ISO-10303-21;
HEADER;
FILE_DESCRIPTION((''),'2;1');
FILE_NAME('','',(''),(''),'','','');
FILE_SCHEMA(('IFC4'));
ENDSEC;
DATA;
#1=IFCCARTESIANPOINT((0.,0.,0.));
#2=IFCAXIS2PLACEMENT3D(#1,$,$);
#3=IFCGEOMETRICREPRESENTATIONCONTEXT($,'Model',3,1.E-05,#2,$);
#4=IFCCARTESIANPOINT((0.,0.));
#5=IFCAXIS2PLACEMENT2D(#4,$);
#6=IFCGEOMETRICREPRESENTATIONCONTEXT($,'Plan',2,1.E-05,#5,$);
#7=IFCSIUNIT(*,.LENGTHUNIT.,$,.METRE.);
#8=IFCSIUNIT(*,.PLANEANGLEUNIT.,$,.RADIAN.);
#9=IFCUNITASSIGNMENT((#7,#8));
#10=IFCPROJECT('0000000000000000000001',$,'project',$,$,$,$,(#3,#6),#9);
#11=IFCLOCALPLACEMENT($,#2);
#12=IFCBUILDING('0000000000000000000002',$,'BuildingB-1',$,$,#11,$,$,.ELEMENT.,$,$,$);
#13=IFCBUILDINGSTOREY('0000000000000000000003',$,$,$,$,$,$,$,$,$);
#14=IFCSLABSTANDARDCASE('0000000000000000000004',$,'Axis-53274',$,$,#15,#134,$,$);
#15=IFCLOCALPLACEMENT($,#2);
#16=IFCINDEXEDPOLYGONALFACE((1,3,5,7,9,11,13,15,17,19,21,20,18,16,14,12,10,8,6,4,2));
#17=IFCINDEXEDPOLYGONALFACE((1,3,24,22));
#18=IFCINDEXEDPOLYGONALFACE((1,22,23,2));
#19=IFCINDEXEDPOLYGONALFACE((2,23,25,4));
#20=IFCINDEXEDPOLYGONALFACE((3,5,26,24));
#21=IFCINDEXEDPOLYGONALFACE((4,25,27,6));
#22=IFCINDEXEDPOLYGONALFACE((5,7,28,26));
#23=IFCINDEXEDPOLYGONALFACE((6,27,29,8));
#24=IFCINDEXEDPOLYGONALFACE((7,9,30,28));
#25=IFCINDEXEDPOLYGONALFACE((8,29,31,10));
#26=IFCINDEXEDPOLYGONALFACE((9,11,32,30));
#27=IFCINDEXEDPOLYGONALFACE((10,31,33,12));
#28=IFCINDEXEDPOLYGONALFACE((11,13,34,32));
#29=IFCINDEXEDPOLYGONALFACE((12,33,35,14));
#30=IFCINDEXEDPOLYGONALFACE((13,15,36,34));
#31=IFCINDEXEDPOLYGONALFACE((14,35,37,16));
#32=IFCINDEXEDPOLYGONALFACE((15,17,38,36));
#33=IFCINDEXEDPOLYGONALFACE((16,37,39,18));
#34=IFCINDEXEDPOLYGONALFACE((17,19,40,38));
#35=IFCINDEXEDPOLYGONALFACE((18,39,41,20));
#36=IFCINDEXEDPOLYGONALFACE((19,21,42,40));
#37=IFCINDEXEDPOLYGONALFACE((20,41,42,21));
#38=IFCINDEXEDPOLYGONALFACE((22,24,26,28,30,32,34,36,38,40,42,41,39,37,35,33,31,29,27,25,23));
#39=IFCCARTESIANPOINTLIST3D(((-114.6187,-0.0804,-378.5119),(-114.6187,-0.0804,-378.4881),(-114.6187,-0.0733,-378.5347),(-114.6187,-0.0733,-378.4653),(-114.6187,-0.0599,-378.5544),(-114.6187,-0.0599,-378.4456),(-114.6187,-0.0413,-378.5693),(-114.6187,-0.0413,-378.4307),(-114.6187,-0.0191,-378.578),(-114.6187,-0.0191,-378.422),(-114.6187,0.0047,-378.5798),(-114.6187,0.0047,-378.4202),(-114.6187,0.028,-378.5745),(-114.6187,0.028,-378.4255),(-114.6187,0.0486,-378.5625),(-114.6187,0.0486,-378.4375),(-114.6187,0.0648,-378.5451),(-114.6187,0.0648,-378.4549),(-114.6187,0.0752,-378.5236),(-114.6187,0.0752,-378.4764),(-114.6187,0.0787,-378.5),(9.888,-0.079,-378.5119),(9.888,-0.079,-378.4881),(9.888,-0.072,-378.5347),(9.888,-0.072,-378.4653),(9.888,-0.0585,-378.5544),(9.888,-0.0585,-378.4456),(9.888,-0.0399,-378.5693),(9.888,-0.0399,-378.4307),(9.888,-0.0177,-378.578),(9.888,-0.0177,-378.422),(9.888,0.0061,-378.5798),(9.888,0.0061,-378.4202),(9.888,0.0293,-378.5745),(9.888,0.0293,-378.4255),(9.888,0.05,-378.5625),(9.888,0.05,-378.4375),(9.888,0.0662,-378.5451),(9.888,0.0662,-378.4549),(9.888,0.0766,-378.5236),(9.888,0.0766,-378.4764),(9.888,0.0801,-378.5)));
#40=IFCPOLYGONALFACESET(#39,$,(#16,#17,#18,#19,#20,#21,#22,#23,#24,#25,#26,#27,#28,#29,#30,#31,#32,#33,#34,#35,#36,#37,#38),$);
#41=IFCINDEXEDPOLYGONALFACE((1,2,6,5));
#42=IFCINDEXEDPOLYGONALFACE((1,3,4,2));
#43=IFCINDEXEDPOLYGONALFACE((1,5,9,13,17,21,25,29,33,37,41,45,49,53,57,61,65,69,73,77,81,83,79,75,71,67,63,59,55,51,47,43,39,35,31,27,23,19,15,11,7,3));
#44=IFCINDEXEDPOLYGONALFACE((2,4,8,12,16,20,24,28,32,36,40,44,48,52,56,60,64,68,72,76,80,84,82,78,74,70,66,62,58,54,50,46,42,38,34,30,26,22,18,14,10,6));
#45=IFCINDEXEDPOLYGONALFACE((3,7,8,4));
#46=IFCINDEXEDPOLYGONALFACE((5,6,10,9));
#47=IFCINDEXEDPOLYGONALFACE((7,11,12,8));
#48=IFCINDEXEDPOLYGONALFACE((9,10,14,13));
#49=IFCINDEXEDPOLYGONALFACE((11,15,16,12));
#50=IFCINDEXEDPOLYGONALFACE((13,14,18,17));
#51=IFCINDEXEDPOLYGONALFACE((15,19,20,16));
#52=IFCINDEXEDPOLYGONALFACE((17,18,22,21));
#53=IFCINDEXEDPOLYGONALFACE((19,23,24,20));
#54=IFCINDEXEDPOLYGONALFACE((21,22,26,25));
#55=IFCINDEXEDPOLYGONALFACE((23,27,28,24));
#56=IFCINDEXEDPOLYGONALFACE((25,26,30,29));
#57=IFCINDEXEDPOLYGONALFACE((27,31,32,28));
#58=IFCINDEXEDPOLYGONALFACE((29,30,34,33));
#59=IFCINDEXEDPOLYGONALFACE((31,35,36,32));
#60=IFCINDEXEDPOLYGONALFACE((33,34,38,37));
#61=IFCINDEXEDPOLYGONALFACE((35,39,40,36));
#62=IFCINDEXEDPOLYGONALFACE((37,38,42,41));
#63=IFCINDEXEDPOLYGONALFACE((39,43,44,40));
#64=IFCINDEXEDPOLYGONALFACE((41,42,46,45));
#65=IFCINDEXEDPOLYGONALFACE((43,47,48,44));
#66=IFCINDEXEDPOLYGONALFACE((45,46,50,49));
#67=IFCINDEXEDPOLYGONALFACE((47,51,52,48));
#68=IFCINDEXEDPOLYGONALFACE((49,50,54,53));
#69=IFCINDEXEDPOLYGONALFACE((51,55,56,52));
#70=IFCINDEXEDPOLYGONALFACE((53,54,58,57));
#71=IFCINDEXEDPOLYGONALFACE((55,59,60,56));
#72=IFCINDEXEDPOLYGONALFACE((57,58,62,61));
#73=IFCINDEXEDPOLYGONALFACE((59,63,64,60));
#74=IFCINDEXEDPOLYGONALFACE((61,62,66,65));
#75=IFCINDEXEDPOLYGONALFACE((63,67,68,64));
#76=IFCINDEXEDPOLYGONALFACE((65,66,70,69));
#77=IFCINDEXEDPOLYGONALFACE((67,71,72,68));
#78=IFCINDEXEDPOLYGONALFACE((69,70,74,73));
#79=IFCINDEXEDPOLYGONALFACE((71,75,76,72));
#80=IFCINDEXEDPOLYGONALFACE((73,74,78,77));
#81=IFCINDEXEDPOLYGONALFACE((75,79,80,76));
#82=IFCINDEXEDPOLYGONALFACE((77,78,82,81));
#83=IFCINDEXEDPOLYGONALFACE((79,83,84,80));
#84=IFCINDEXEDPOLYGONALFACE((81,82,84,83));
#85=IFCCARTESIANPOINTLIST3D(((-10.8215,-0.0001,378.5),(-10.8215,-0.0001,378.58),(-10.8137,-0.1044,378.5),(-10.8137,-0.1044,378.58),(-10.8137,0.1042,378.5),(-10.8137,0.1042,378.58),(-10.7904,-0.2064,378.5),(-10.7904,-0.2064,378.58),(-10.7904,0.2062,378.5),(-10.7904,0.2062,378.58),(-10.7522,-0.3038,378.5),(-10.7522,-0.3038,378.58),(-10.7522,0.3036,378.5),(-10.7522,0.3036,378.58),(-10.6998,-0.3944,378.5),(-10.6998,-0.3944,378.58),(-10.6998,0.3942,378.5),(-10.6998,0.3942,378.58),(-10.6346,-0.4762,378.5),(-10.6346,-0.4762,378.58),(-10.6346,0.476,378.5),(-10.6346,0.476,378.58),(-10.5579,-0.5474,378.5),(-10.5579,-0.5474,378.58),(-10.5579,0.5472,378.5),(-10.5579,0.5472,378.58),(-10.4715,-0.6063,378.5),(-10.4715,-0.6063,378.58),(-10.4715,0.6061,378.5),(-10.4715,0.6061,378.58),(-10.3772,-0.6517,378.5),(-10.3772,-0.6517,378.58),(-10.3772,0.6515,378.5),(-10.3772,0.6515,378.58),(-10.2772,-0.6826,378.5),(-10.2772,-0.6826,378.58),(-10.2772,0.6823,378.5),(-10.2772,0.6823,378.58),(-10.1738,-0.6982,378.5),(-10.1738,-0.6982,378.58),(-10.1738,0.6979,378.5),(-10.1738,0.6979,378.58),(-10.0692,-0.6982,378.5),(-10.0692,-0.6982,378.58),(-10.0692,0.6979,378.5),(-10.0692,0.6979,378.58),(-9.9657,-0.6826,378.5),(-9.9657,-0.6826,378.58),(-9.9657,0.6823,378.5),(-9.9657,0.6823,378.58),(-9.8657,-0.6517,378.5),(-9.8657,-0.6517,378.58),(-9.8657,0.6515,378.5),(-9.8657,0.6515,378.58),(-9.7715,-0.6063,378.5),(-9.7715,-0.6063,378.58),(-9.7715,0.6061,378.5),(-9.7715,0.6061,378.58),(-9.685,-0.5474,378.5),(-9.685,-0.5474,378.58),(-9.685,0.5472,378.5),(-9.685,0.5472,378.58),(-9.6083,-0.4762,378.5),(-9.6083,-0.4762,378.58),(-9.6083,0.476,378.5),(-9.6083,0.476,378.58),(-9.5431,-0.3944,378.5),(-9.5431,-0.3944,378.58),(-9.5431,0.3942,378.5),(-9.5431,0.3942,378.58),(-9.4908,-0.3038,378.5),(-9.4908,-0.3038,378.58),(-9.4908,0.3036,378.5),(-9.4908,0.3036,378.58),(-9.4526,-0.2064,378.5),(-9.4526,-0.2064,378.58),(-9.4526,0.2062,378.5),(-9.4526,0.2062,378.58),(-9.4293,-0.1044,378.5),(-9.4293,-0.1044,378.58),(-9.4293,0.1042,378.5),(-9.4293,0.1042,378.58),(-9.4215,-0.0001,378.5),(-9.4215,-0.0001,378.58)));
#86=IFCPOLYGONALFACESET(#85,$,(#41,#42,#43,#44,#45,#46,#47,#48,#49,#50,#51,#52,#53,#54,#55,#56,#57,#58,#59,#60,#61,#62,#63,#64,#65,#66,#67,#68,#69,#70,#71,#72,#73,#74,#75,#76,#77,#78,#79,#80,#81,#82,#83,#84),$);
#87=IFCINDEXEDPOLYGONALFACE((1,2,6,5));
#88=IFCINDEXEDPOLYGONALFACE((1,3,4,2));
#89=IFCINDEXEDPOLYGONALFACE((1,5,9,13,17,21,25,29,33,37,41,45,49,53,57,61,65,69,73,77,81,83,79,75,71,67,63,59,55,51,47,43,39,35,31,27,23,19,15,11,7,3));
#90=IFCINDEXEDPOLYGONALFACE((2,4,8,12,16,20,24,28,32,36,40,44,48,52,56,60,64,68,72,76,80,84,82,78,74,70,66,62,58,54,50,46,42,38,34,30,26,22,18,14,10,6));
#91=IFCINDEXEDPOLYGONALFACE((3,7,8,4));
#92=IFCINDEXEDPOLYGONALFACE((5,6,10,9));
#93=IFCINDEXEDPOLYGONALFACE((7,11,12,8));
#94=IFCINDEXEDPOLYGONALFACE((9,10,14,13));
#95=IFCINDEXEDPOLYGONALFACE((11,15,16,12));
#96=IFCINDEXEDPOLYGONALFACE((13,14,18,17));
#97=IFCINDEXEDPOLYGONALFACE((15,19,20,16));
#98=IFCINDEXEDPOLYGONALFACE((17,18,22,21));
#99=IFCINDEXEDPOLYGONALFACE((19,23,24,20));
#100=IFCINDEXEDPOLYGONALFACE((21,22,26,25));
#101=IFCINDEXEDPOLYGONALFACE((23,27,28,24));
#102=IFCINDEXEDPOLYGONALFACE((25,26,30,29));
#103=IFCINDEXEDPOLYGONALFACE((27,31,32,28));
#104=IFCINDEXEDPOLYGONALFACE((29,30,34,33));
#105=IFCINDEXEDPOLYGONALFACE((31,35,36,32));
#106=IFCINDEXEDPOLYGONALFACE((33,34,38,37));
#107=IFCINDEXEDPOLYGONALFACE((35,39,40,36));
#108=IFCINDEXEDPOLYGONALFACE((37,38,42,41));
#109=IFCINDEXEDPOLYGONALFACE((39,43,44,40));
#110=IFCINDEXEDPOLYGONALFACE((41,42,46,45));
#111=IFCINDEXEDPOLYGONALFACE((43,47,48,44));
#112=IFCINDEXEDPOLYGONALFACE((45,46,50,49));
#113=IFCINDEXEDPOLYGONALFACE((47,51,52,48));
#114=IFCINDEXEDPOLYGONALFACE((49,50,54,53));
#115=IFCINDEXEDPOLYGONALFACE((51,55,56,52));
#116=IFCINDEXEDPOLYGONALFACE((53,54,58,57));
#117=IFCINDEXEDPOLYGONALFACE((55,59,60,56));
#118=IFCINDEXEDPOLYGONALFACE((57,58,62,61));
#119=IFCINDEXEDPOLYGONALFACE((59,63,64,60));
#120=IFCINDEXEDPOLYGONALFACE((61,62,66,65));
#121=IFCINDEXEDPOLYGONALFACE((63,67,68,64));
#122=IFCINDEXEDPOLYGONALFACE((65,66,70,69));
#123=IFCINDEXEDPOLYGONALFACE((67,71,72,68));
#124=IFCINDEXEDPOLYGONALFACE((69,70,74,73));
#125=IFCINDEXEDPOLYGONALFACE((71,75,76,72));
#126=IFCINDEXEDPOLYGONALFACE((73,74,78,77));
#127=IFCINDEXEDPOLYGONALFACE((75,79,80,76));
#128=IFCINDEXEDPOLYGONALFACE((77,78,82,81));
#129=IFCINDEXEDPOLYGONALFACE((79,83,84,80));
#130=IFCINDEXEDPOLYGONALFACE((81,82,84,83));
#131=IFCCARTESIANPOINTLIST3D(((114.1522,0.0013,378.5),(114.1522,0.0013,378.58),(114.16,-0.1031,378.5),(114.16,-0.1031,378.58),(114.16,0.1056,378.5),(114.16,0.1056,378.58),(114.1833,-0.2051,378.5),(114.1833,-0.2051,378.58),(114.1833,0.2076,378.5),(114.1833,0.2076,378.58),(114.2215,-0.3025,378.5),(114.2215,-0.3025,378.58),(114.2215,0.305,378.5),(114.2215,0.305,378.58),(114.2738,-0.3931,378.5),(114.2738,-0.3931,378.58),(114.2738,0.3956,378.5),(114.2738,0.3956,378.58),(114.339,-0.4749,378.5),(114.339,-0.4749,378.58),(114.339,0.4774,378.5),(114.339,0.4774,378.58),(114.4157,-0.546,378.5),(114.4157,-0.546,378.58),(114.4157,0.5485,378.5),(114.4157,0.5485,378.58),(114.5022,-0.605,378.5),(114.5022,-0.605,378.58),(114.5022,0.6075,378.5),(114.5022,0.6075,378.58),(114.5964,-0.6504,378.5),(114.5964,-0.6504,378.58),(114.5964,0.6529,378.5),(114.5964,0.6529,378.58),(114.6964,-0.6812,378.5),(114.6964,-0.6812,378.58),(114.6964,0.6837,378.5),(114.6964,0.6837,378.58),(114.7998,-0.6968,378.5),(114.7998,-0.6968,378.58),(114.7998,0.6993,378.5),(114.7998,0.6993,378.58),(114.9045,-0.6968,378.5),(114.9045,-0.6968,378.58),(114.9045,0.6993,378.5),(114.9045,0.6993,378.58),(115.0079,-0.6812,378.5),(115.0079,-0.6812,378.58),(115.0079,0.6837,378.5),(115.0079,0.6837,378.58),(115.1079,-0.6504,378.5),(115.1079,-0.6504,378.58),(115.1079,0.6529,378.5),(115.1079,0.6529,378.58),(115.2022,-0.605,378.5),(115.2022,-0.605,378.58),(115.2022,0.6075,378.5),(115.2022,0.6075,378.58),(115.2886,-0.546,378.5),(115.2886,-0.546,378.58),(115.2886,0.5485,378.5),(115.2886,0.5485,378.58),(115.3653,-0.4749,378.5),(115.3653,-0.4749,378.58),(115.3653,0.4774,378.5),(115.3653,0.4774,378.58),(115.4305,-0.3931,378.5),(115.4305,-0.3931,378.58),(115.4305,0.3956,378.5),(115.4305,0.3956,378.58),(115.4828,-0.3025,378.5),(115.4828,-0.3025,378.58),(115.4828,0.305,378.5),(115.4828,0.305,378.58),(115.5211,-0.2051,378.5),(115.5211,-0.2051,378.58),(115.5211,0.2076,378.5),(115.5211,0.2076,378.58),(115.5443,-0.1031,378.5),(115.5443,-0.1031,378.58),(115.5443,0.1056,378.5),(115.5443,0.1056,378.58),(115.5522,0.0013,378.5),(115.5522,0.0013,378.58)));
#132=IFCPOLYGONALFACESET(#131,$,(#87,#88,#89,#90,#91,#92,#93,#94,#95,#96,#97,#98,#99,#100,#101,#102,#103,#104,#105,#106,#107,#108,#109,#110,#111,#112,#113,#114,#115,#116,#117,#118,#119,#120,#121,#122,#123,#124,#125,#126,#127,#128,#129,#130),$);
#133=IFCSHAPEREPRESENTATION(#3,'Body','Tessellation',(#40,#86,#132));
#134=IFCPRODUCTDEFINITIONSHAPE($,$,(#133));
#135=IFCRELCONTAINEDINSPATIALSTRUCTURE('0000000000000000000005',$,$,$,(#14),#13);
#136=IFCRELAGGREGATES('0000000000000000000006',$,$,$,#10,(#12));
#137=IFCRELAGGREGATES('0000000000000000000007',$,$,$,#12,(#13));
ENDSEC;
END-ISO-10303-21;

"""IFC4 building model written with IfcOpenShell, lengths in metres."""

from ifc_helpers import new_model, entity, si_unit, frame, origin, origin_2d, place, context, project, spatial, circle, extrude, element, save


model = new_model("IFC4")

# Units and contexts
model_context = context("Model", 3, precision=1e-05, world=origin())
plan_context = context("Plan", 2, precision=1e-05, world=origin_2d())
ifc_project = project(units=[si_unit("LENGTHUNIT", "METRE"), si_unit("PLANEANGLEUNIT", "RADIAN")], contexts=[model_context, plan_context])

# Building, storey
building_placement = place(None, origin())
building = spatial("IfcBuilding", under=ifc_project, at=building_placement, Name="BuildingB-1", CompositionType="ELEMENT")
storey = spatial("IfcBuildingStorey", under=building)

# Slab
element("IfcSlabStandardCase", 1, inside=storey, Name="Axis-53274", context=model_context, shape_type="AdvancedSweptSolid", body=[
    entity("IfcSurfaceCurveSweptAreaSolid", entity("IfcCircleProfileDef", "AREA", None, None, 0.08), None, entity("IfcPolyline", [entity("IfcCartesianPoint", [-9.888, -0.0001, 378.5]), entity("IfcCartesianPoint", [114.6187, 0.0013, 378.5])]), None, None, entity("IfcPlane", entity("IfcAxis2Placement3D", entity("IfcCartesianPoint", [-9.888, -0.0001, 378.5]), entity("IfcDirection", [0.0, 0.0, 1.0]), entity("IfcDirection", [1.0, 0.0, 0.0])))),
    extrude(circle(Radius=0.7), frame((-10.1215, -0.0001, 378.5)), (0.0, 0.0, 1.0), 0.08),
    extrude(circle(Radius=0.7), frame((114.8522, 0.0013, 378.5)), (0.0, 0.0, 1.0), 0.08),
])

save(model, "model.ifc")
